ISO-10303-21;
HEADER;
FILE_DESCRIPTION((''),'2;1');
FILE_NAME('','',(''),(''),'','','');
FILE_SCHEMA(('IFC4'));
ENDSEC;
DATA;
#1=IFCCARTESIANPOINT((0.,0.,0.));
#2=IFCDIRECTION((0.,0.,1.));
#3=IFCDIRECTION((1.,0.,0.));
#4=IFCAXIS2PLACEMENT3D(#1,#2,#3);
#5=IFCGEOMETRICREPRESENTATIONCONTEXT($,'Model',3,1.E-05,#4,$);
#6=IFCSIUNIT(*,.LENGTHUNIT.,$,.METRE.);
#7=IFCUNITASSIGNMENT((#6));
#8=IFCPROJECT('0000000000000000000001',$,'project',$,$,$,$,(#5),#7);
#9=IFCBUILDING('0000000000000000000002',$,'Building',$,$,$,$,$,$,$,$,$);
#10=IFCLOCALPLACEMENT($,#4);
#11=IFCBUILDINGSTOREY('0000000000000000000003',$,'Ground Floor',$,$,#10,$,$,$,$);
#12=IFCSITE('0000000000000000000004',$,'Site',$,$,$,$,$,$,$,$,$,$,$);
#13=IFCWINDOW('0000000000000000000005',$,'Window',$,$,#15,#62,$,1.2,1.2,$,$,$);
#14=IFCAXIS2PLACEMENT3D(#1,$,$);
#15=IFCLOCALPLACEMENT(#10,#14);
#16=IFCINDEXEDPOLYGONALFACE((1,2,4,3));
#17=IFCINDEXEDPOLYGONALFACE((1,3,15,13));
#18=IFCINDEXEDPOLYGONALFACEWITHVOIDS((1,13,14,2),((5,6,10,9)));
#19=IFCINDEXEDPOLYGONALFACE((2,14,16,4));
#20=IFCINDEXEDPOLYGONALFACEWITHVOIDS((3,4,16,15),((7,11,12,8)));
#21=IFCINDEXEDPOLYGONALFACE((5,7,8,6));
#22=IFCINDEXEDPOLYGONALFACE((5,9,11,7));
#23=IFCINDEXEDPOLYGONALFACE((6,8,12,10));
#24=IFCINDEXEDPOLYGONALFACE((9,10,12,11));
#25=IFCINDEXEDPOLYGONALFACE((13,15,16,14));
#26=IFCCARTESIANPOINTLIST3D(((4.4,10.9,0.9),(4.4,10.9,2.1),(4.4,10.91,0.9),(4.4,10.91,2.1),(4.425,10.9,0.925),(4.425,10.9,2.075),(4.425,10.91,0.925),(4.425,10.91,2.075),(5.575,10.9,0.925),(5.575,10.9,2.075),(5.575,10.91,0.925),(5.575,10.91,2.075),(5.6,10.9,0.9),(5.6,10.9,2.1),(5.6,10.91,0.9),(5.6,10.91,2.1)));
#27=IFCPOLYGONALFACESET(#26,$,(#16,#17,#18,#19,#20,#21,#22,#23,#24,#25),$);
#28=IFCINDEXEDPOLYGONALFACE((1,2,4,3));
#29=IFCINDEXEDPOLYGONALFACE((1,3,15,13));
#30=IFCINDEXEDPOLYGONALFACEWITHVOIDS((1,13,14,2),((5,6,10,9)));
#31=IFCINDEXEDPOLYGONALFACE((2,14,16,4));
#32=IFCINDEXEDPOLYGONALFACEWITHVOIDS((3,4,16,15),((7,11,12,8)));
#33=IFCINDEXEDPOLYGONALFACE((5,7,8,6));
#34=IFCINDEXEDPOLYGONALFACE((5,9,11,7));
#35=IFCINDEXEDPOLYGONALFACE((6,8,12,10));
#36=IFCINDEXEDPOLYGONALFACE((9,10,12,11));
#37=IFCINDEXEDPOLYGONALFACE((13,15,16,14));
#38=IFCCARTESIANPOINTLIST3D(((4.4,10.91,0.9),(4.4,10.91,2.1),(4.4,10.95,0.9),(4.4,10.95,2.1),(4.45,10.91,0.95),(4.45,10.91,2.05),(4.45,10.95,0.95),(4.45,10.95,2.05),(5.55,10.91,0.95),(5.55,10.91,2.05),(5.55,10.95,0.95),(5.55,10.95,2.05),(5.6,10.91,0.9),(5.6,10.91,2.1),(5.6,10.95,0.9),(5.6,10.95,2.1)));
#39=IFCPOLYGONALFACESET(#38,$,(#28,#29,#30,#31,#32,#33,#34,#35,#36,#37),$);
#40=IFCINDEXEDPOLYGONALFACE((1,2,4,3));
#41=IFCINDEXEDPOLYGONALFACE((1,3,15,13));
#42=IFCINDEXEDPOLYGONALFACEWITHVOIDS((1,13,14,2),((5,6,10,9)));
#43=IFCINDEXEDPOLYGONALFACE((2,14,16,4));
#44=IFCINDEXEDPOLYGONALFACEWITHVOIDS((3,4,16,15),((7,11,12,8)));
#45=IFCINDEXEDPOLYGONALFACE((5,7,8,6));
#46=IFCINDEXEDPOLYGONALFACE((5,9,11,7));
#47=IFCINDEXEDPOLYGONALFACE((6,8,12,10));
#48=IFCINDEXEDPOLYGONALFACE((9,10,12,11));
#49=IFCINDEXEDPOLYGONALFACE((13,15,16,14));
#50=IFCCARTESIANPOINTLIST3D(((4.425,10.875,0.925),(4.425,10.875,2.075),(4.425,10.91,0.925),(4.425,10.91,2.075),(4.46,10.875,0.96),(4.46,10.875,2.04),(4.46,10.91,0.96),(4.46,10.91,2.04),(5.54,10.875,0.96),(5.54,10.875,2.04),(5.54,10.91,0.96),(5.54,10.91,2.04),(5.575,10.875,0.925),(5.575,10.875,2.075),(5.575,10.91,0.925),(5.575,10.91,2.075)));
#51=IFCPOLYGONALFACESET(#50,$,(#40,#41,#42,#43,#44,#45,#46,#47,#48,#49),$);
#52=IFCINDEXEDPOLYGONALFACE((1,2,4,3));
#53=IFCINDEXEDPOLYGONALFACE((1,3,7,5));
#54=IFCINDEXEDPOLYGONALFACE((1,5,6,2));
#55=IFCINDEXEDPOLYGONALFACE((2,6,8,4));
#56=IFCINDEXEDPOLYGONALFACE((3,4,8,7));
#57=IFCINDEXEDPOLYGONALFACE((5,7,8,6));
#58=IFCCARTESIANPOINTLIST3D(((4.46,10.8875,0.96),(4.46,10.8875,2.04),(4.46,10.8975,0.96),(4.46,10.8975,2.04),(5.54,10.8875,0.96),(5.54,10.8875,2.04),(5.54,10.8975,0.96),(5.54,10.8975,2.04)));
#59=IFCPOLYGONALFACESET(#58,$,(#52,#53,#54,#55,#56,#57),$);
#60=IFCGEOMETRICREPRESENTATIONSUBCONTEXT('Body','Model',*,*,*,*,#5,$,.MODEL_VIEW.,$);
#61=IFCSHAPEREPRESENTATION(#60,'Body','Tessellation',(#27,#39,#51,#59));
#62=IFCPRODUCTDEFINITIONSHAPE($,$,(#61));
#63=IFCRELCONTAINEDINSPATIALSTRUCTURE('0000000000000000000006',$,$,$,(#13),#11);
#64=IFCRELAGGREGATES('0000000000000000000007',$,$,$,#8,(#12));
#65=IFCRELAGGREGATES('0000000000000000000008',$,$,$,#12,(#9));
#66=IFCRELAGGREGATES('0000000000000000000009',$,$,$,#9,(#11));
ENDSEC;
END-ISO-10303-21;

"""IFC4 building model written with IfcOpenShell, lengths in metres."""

from ifc_helpers import new_model, si_unit, frame, origin_with_axes, place, context, subcontext, project, spatial, line, indexed_curve, outline, extrude, element, save


model = new_model("IFC4")

# Units and contexts
model_context = context("Model", 3, precision=1e-05, world=origin_with_axes())
body_context = subcontext(model_context, "Body", "Model", "MODEL_VIEW")
ifc_project = project(units=[si_unit("LENGTHUNIT", "METRE")], contexts=[model_context])

# Site, building, storey
site = spatial("IfcSite", under=ifc_project, Name="Site")
building = spatial("IfcBuilding", under=site, Name="Building")
storey_placement = place(None, origin_with_axes())
storey = spatial("IfcBuildingStorey", under=building, at=storey_placement, Name="Ground Floor")

# Window
window_1_placement = place(storey_placement, frame((5.6, 11.0, 0.9), z_axis=(0.0, 0.0, 1.0), x_axis=(-1.0, 0.0, 0.0)))
element("IfcWindow", 1, at=window_1_placement, inside=storey, Name="Window", OverallHeight=1.2, OverallWidth=1.2, context=body_context, shape_type="SweptSolid", body=[
    extrude(outline(indexed_curve([(0.0, 0.0), (1.2, 0.0), (1.2, 1.2), (0.0, 1.2)], segments=[line(1, 2, 3, 4, 1)]), holes=[indexed_curve([(0.025, 0.025), (1.175, 0.025), (1.175, 1.175), (0.025, 1.175)], segments=[line(1, 2, 3, 4, 1)])]), frame((0.0, 0.09, 0.0), z_axis=(0.0, -1.0, 0.0), x_axis=(1.0, 0.0, 0.0)), (0.0, 0.0, -1.0), 0.01),
    extrude(outline(indexed_curve([(0.0, 0.0), (1.2, 0.0), (1.2, 1.2), (0.0, 1.2)], segments=[line(1, 2, 3, 4, 1)]), holes=[indexed_curve([(0.05, 0.05), (1.15, 0.05), (1.15, 1.15), (0.05, 1.15)], segments=[line(1, 2, 3, 4, 1)])]), frame((0.0, 0.05, 0.0), z_axis=(0.0, -1.0, 0.0), x_axis=(1.0, 0.0, 0.0)), (0.0, 0.0, -1.0), 0.04),
    extrude(outline(indexed_curve([(0.0, 0.0), (1.15, 0.0), (1.15, 1.15), (0.0, 1.15)], segments=[line(1, 2, 3, 4, 1)]), holes=[indexed_curve([(0.035, 0.035), (1.115, 0.035), (1.115, 1.115), (0.035, 1.115)], segments=[line(1, 2, 3, 4, 1)])]), frame((0.025, 0.09, 0.025), z_axis=(0.0, -1.0, 0.0), x_axis=(1.0, 0.0, 0.0)), (0.0, 0.0, -1.0), 0.035),
    extrude(outline(indexed_curve([(0.035, 0.035), (1.115, 0.035), (1.115, 1.115), (0.035, 1.115)], segments=[line(1, 2, 3, 4, 1)])), frame((0.025, 0.1025, 0.025), z_axis=(0.0, -1.0, 0.0), x_axis=(1.0, 0.0, 0.0)), (0.0, 0.0, -1.0), 0.01),
])

save(model, "model.ifc")
